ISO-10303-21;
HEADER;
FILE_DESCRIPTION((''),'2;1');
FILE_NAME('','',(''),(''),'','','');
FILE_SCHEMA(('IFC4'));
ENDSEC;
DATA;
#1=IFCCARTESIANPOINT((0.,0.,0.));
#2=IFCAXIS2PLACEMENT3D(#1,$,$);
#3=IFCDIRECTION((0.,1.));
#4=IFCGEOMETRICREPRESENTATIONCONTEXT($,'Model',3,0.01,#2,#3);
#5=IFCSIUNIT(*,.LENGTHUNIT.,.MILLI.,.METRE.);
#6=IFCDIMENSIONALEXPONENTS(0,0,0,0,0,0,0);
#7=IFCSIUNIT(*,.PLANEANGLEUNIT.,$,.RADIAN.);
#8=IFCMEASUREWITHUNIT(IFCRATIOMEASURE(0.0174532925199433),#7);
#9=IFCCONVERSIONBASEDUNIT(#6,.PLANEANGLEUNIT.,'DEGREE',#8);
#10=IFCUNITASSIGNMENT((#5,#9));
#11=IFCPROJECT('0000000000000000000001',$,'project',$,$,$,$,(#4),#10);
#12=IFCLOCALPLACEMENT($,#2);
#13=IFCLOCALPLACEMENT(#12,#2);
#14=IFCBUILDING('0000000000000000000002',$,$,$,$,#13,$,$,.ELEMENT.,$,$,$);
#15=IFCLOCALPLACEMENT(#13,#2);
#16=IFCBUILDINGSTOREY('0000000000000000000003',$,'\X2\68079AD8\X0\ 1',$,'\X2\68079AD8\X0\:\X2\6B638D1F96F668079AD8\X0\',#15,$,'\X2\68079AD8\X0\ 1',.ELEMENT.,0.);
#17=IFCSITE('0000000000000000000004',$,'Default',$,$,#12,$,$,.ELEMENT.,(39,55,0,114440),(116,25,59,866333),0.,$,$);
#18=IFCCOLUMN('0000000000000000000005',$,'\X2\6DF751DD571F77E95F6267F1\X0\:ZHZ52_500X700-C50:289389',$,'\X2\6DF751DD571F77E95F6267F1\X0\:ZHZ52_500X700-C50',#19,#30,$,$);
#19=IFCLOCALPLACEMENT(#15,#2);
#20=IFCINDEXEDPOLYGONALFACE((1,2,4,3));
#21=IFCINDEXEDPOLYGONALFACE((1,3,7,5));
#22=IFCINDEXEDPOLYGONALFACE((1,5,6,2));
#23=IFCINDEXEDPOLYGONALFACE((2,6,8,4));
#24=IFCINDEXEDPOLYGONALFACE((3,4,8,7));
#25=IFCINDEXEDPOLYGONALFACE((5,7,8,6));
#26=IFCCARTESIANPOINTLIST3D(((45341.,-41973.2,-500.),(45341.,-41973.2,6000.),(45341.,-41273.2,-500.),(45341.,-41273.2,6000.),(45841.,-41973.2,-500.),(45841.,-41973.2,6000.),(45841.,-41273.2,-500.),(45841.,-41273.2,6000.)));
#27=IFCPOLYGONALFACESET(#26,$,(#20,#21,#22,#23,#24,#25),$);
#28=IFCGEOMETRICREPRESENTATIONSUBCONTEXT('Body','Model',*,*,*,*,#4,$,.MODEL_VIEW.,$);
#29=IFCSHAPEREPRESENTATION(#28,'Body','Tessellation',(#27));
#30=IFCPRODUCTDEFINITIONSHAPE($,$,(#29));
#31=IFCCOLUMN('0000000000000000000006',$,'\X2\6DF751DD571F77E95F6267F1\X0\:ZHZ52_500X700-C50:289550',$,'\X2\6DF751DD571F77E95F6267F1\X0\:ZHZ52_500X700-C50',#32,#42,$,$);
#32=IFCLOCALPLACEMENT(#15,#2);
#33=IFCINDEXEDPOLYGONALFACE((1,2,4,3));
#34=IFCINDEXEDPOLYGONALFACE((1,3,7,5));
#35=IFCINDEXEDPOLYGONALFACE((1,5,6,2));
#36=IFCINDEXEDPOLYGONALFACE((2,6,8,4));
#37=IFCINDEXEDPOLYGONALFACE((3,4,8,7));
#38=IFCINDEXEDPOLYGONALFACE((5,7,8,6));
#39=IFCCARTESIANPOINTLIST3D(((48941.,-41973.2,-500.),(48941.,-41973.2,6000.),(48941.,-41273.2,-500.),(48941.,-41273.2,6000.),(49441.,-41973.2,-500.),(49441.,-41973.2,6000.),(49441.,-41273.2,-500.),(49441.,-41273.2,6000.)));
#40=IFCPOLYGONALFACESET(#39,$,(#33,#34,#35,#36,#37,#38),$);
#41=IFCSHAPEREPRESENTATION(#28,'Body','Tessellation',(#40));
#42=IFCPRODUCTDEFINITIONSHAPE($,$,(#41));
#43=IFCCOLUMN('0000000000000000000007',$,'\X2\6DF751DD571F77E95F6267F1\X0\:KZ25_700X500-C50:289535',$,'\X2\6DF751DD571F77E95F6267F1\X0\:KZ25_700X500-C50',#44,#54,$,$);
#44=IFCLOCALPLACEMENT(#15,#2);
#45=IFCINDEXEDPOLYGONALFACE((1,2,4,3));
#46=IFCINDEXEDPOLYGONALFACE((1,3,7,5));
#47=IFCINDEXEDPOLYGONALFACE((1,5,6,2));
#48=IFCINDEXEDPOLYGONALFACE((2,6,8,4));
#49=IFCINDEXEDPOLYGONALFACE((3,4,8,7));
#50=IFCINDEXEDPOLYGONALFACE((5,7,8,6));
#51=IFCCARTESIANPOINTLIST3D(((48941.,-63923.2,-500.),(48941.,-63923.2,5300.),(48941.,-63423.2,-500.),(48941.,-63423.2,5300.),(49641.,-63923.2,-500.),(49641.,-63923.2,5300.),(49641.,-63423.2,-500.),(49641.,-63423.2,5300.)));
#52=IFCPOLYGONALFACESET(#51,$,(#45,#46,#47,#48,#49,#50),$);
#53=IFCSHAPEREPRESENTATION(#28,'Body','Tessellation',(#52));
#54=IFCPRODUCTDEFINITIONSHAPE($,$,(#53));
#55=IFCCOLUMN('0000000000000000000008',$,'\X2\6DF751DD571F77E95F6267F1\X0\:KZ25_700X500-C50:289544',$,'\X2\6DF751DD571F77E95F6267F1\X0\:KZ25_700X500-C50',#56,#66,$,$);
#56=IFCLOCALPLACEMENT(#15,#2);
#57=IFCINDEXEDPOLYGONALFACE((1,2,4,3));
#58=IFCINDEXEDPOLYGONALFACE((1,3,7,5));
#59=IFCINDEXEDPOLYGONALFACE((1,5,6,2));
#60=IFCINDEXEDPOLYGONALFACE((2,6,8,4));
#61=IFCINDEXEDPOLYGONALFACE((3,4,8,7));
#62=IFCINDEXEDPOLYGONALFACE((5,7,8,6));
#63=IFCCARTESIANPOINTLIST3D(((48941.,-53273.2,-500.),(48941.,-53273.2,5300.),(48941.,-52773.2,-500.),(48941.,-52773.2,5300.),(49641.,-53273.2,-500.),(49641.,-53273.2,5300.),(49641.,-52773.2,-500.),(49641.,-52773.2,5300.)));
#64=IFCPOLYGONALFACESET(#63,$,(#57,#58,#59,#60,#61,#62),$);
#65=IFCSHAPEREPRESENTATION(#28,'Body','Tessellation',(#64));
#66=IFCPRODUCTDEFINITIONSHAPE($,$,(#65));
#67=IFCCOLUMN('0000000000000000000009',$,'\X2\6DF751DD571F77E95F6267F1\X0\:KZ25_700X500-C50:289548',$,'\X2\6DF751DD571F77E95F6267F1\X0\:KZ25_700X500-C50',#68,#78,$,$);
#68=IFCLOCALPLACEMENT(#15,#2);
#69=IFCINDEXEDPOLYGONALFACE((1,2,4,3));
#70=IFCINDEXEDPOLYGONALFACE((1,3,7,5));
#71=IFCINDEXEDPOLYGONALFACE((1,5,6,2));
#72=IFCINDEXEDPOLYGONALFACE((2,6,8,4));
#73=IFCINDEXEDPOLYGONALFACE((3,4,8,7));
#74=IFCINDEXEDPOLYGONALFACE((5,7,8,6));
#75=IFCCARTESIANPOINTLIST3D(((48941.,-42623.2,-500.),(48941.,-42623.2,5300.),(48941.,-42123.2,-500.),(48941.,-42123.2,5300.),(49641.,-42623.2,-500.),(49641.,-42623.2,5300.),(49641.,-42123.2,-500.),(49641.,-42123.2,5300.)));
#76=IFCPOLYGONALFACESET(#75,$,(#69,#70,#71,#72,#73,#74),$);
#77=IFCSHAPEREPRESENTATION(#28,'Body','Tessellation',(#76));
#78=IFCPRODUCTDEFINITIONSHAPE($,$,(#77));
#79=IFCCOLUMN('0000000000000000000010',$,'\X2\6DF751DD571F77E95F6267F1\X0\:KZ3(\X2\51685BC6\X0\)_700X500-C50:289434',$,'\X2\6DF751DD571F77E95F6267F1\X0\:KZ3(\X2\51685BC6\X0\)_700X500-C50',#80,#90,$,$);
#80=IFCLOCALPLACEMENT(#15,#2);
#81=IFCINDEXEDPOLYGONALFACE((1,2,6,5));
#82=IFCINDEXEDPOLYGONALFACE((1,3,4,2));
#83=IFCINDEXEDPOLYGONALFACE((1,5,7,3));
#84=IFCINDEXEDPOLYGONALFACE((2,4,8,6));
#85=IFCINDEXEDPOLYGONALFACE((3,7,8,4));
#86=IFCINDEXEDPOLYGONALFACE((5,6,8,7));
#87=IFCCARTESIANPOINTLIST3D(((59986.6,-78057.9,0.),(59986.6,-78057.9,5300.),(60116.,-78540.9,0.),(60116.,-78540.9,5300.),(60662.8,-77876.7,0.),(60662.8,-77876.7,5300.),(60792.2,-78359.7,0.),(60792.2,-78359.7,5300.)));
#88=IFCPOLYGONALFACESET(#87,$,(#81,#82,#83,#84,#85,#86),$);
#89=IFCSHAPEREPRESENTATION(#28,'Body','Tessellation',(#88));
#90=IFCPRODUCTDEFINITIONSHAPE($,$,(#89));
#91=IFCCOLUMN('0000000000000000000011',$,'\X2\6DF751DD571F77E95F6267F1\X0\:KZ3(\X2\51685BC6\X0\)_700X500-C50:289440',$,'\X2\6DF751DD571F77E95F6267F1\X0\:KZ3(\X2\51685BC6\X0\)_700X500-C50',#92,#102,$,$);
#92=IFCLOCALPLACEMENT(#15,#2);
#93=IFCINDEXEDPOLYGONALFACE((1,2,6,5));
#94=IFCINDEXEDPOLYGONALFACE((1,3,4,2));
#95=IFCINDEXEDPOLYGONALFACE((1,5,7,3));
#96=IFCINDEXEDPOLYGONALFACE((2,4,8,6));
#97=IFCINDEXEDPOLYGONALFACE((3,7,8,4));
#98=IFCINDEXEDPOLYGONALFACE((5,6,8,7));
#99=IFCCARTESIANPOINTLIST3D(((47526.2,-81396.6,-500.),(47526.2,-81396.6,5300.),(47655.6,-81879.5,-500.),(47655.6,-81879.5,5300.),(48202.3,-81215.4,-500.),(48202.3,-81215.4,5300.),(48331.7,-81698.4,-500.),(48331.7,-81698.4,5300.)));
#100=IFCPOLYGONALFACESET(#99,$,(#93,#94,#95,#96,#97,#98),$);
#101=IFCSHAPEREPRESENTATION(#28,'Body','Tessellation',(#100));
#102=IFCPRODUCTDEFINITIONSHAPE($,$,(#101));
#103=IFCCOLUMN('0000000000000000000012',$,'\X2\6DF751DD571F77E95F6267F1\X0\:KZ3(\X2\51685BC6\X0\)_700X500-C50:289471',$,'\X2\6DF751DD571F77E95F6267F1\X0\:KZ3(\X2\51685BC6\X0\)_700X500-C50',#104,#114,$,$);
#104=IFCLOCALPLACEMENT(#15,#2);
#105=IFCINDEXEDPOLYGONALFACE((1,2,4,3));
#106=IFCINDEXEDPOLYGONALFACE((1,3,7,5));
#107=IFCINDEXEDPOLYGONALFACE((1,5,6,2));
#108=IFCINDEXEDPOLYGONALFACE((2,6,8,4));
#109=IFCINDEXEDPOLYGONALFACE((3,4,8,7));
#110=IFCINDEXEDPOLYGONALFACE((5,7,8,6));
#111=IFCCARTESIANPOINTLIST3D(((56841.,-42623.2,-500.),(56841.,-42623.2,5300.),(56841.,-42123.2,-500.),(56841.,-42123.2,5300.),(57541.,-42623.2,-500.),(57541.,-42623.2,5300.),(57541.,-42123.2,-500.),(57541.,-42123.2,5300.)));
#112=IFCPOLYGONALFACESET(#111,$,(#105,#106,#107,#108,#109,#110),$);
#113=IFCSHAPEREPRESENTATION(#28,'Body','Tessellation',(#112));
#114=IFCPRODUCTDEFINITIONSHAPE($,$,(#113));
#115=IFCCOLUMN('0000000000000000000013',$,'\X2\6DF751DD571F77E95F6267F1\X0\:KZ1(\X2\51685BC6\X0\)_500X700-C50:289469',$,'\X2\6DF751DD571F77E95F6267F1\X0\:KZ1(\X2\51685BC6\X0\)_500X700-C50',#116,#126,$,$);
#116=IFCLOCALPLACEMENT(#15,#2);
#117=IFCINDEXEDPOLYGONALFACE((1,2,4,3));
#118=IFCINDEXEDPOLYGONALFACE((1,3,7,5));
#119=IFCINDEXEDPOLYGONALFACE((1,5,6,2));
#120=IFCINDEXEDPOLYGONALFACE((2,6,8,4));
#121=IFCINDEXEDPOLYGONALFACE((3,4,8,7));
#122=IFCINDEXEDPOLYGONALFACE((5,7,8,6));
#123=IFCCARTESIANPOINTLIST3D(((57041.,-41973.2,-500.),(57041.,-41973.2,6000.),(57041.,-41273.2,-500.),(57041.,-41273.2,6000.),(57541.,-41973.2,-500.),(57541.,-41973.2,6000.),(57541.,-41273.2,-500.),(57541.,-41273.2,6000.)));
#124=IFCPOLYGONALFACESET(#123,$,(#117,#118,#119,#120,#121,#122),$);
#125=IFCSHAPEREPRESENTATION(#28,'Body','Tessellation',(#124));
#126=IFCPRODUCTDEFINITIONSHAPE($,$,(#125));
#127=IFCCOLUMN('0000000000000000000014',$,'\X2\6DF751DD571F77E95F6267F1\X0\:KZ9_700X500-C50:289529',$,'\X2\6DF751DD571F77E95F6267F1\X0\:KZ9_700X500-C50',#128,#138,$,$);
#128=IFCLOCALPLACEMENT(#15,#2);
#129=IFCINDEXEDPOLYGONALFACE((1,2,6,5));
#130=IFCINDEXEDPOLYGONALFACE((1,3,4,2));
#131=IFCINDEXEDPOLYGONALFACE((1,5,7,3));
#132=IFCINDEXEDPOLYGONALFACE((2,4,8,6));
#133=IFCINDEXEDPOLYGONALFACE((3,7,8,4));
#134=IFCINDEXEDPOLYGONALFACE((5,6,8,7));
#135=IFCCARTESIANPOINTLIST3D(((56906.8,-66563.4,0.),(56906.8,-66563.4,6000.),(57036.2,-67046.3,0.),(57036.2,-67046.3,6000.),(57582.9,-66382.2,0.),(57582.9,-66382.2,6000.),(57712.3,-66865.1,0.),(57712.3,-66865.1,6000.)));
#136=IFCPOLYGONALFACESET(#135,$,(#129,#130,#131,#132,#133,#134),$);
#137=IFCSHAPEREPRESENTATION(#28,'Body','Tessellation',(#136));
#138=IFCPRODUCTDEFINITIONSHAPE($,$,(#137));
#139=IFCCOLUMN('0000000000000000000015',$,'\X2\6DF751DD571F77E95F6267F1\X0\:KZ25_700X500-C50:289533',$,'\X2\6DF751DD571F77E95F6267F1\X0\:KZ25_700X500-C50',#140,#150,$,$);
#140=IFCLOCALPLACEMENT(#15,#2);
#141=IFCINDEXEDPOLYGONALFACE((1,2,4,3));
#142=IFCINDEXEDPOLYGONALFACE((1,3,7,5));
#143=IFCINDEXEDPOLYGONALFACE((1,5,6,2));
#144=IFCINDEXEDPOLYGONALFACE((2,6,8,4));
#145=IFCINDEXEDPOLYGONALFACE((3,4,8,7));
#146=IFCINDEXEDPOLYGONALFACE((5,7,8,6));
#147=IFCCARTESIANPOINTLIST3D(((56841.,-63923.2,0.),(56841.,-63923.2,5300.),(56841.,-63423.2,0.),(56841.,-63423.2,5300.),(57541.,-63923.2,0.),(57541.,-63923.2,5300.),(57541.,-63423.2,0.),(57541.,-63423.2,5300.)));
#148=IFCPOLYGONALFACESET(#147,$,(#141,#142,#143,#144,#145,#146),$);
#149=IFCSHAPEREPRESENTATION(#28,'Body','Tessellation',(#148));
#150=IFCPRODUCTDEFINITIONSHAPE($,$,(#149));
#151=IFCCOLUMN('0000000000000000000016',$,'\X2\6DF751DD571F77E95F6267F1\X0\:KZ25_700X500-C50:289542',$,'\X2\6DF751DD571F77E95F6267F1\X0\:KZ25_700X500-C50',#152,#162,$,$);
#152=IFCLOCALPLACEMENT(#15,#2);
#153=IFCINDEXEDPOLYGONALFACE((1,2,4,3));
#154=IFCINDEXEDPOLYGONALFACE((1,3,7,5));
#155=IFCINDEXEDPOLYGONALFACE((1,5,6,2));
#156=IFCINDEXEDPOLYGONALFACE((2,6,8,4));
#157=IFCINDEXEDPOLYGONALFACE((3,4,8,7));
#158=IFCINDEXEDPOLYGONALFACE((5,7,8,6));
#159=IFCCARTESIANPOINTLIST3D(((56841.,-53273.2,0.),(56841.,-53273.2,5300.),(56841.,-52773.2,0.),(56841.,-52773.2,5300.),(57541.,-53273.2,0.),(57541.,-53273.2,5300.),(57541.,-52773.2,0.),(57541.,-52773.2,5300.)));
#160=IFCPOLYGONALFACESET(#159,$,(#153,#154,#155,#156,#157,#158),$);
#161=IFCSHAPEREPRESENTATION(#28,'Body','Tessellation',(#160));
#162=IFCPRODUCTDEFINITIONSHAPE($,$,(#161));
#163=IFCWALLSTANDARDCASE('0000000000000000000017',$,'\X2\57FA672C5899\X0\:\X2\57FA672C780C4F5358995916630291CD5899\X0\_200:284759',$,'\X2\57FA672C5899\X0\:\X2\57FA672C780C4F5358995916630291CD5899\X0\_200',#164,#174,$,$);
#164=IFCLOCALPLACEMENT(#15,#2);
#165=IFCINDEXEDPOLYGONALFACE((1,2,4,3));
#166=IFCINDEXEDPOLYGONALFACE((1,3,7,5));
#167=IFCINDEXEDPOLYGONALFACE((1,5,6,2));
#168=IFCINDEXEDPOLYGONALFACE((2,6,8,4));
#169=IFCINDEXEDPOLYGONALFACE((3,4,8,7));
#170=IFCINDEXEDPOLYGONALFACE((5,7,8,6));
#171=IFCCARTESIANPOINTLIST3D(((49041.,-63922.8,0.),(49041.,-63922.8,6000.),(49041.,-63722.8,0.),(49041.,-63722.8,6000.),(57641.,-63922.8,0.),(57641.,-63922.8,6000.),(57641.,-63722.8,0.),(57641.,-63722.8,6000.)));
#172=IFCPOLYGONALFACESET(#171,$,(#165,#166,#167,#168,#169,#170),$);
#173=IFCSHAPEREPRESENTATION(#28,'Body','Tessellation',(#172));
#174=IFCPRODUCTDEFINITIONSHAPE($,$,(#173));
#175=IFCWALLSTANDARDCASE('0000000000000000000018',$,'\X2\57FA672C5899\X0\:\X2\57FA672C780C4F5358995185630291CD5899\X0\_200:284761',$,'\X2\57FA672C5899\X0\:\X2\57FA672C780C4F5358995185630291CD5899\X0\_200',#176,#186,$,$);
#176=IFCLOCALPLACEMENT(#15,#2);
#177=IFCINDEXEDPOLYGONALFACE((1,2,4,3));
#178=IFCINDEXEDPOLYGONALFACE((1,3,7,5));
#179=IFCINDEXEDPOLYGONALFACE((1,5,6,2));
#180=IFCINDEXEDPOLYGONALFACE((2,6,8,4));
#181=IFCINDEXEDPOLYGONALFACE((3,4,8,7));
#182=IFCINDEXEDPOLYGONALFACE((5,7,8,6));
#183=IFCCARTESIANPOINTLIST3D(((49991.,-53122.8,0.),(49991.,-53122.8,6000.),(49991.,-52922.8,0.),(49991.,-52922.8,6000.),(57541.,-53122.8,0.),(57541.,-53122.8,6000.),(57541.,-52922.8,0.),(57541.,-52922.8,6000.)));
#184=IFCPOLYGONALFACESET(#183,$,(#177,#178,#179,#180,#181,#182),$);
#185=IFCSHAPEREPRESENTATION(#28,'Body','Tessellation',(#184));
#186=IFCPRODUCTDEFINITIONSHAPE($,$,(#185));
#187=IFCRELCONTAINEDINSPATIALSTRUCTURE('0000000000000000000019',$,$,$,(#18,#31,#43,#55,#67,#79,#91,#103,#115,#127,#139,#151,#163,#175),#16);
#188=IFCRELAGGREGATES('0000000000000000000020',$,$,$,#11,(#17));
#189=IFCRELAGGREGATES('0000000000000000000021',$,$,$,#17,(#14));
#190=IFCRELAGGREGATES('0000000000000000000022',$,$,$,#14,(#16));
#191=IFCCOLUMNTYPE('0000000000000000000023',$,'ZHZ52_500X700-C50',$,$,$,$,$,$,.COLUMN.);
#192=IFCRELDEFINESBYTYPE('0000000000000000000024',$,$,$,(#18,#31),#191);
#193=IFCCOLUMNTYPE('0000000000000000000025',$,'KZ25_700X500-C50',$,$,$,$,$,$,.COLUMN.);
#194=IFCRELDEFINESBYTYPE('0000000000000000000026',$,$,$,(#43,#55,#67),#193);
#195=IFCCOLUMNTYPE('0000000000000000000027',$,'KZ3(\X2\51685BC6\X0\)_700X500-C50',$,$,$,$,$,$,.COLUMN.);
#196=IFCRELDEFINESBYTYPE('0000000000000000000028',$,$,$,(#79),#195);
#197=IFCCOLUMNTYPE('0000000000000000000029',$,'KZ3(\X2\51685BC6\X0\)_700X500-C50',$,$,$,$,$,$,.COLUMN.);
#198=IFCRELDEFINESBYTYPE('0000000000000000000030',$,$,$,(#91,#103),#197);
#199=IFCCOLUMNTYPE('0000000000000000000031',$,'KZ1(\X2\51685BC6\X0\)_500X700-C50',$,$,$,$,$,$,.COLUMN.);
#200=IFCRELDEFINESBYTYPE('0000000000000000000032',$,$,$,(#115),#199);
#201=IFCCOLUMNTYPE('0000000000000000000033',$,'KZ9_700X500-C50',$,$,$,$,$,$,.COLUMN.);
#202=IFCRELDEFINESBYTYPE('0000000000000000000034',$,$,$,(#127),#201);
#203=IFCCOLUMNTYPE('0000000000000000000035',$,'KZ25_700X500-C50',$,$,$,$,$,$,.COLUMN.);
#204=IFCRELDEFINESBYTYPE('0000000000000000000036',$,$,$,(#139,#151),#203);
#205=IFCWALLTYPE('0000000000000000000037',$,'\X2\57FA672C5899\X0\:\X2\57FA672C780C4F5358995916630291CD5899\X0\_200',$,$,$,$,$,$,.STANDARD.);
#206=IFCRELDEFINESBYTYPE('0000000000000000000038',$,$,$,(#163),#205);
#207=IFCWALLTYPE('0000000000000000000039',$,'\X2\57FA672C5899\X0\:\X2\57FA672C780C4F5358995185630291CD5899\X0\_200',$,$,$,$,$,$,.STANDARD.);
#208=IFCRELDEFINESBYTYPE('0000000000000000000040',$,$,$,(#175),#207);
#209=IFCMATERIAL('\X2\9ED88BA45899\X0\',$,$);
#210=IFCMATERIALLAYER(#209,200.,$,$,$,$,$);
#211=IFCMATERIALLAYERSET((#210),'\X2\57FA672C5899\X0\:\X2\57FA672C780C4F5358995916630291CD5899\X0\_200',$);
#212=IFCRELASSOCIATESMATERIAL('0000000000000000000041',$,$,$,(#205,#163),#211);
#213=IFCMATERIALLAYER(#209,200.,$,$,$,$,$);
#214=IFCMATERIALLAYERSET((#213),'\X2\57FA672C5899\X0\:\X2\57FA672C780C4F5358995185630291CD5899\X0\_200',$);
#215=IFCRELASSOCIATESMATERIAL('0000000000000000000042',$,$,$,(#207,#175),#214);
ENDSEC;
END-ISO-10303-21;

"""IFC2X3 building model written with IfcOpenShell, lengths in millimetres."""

from ifc_helpers import new_model, entity, si_unit, converted_unit, direction, frame, frame_2d, origin, origin_2d_with_axis, place, context, subcontext, project, spatial, rectangle, extrude, source, transform, mapped, material, layer, layer_set, layer_usage, type_object, type_shapes, element, save


model = new_model("IFC2X3")

# Units and contexts
model_context = context("Model", 3, precision=0.01, world=origin(), true_north=direction((0.0, 1.0)))
body_context = subcontext(model_context, "Body", "Model", "MODEL_VIEW")
ifc_project = project(units=[si_unit("LENGTHUNIT", "METRE", prefix="MILLI"), converted_unit("PLANEANGLEUNIT", "DEGREE", entity("IfcRatioMeasure", 0.0174532925199433), si_unit("PLANEANGLEUNIT", "RADIAN"), dimensions=[0, 0, 0, 0, 0, 0, 0])], contexts=[model_context])

# Site, building, storey
site_placement = place(None, origin())
site = spatial("IfcSite", under=ifc_project, at=site_placement, Name="Default", CompositionType="ELEMENT", RefLatitude=(39, 55, 0, 114440), RefLongitude=(116, 25, 59, 866333), RefElevation=0.0)
building_placement = place(site_placement, origin())
building = spatial("IfcBuilding", under=site, at=building_placement, CompositionType="ELEMENT")
storey_placement = place(building_placement, origin())
storey = spatial("IfcBuildingStorey", under=building, at=storey_placement, Name="标高 1", ObjectType="标高:正负零标高", LongName="标高 1", CompositionType="ELEMENT", Elevation=0.0)

# Columns
column_type_1 = type_object("IfcColumnType", Name="ZHZ52_500X700-C50", PredefinedType="COLUMN")
shared_shape_1 = source(origin(), body_context, "Body", "SweptSolid", [
    extrude(rectangle(XDim=700.0, YDim=500.0, at=origin_2d_with_axis()), frame((0.0, 0.0, -500.0), z_axis=(0.0, 0.0, 1.0), x_axis=(0.0, -1.0, 0.0)), (0.0, 0.0, 1.0), 6500.0),
])
type_shapes(column_type_1, [shared_shape_1])
for number, where, name in (
    (1, (45591.0, -41623.2, 0.0), "混凝土矩形柱:ZHZ52_500X700-C50:289389"),
    (2, (49191.0, -41623.2, 0.0), "混凝土矩形柱:ZHZ52_500X700-C50:289550"),
):
    element("IfcColumn", number, at=place(building_placement, frame(where)), inside=storey, type_object=column_type_1, Name=name, ObjectType="混凝土矩形柱:ZHZ52_500X700-C50", context=body_context, shape_type="MappedRepresentation", body=[
        mapped(shared_shape_1, transform((0.0, 0.0, 0.0), scale=1.0)),
    ])
column_type_2 = type_object("IfcColumnType", Name="KZ25_700X500-C50", PredefinedType="COLUMN")
shared_shape_2 = source(origin(), body_context, "Body", "SweptSolid", [
    extrude(rectangle(XDim=500.0, YDim=700.0, at=origin_2d_with_axis()), frame((0.0, 0.0, -500.0), z_axis=(0.0, 0.0, 1.0), x_axis=(0.0, -1.0, 0.0)), (0.0, 0.0, 1.0), 5800.0),
])
type_shapes(column_type_2, [shared_shape_2])
for number, where, name in (
    (3, (49291.0, -63673.2, 0.0), "混凝土矩形柱:KZ25_700X500-C50:289535"),
    (4, (49291.0, -53023.2, 0.0), "混凝土矩形柱:KZ25_700X500-C50:289544"),
    (5, (49291.0, -42373.2, 0.0), "混凝土矩形柱:KZ25_700X500-C50:289548"),
):
    element("IfcColumn", number, at=place(building_placement, frame(where)), inside=storey, type_object=column_type_2, Name=name, ObjectType="混凝土矩形柱:KZ25_700X500-C50", context=body_context, shape_type="MappedRepresentation", body=[
        mapped(shared_shape_2, transform((0.0, 0.0, 0.0), scale=1.0)),
    ])
column_type_3 = type_object("IfcColumnType", Name="KZ3(全密)_700X500-C50", PredefinedType="COLUMN")
shared_shape_3 = source(origin(), body_context, "Body", "SweptSolid", [
    extrude(rectangle(XDim=500.0, YDim=700.0, at=origin_2d_with_axis()), frame((0.0, 0.0, 0.0), z_axis=(0.0, 0.0, 1.0), x_axis=(0.0, -1.0, 0.0)), (0.0, 0.0, 1.0), 5300.0),
])
type_shapes(column_type_3, [shared_shape_3])
column_1_placement = place(building_placement, frame((60389.4, -78208.8, 0.0), z_axis=(0.0, 0.0, 1.0), x_axis=(0.965926, 0.258819, 0.0)))
element("IfcColumn", 6, at=column_1_placement, inside=storey, type_object=column_type_3, Name="混凝土矩形柱:KZ3(全密)_700X500-C50:289434", ObjectType="混凝土矩形柱:KZ3(全密)_700X500-C50", context=body_context, shape_type="MappedRepresentation", body=[
    mapped(shared_shape_3, transform((0.0, 0.0, 0.0), scale=1.0)),
])
column_type_4 = type_object("IfcColumnType", Name="KZ3(全密)_700X500-C50", PredefinedType="COLUMN")
shared_shape_4 = source(origin(), body_context, "Body", "SweptSolid", [
    extrude(rectangle(XDim=500.0, YDim=700.0, at=origin_2d_with_axis()), frame((0.0, 0.0, -500.0), z_axis=(0.0, 0.0, 1.0), x_axis=(0.0, -1.0, 0.0)), (0.0, 0.0, 1.0), 5800.0),
])
type_shapes(column_type_4, [shared_shape_4])
column_2_placement = place(building_placement, frame((47928.9, -81547.5, 0.0), z_axis=(0.0, 0.0, 1.0), x_axis=(0.965926, 0.258819, 0.0)))
element("IfcColumn", 7, at=column_2_placement, inside=storey, type_object=column_type_4, Name="混凝土矩形柱:KZ3(全密)_700X500-C50:289440", ObjectType="混凝土矩形柱:KZ3(全密)_700X500-C50", context=body_context, shape_type="MappedRepresentation", body=[
    mapped(shared_shape_4, transform((0.0, 0.0, 0.0), scale=1.0)),
])
column_3_placement = place(building_placement, frame((57191.0, -42373.2, 0.0)))
element("IfcColumn", 8, at=column_3_placement, inside=storey, type_object=column_type_4, Name="混凝土矩形柱:KZ3(全密)_700X500-C50:289471", ObjectType="混凝土矩形柱:KZ3(全密)_700X500-C50", context=body_context, shape_type="MappedRepresentation", body=[
    mapped(shared_shape_4, transform((0.0, 0.0, 0.0), scale=1.0)),
])
column_type_5 = type_object("IfcColumnType", Name="KZ1(全密)_500X700-C50", PredefinedType="COLUMN")
shared_shape_5 = source(origin(), body_context, "Body", "SweptSolid", [
    extrude(rectangle(XDim=700.0, YDim=500.0, at=origin_2d_with_axis()), frame((0.0, 0.0, -500.0), z_axis=(0.0, 0.0, 1.0), x_axis=(0.0, -1.0, 0.0)), (0.0, 0.0, 1.0), 6500.0),
])
type_shapes(column_type_5, [shared_shape_5])
column_4_placement = place(building_placement, frame((57291.0, -41623.2, 0.0)))
element("IfcColumn", 9, at=column_4_placement, inside=storey, type_object=column_type_5, Name="混凝土矩形柱:KZ1(全密)_500X700-C50:289469", ObjectType="混凝土矩形柱:KZ1(全密)_500X700-C50", context=body_context, shape_type="MappedRepresentation", body=[
    mapped(shared_shape_5, transform((0.0, 0.0, 0.0), scale=1.0)),
])
column_type_6 = type_object("IfcColumnType", Name="KZ9_700X500-C50", PredefinedType="COLUMN")
shared_shape_6 = source(origin(), body_context, "Body", "SweptSolid", [
    extrude(rectangle(XDim=500.0, YDim=700.0, at=origin_2d_with_axis()), frame((0.0, 0.0, 0.0), z_axis=(0.0, 0.0, 1.0), x_axis=(0.0, -1.0, 0.0)), (0.0, 0.0, 1.0), 6000.0),
])
type_shapes(column_type_6, [shared_shape_6])
column_5_placement = place(building_placement, frame((57309.5, -66714.2, 0.0), z_axis=(0.0, 0.0, 1.0), x_axis=(0.965926, 0.258819, 0.0)))
element("IfcColumn", 10, at=column_5_placement, inside=storey, type_object=column_type_6, Name="混凝土矩形柱:KZ9_700X500-C50:289529", ObjectType="混凝土矩形柱:KZ9_700X500-C50", context=body_context, shape_type="MappedRepresentation", body=[
    mapped(shared_shape_6, transform((0.0, 0.0, 0.0), scale=1.0)),
])
column_type_7 = type_object("IfcColumnType", Name="KZ25_700X500-C50", PredefinedType="COLUMN")
shared_shape_7 = source(origin(), body_context, "Body", "SweptSolid", [
    extrude(rectangle(XDim=500.0, YDim=700.0, at=origin_2d_with_axis()), frame((0.0, 0.0, 0.0), z_axis=(0.0, 0.0, 1.0), x_axis=(0.0, -1.0, 0.0)), (0.0, 0.0, 1.0), 5300.0),
])
type_shapes(column_type_7, [shared_shape_7])
for number, where, name in (
    (11, (57191.0, -63673.2, 0.0), "混凝土矩形柱:KZ25_700X500-C50:289533"),
    (12, (57191.0, -53023.2, 0.0), "混凝土矩形柱:KZ25_700X500-C50:289542"),
):
    element("IfcColumn", number, at=place(building_placement, frame(where)), inside=storey, type_object=column_type_7, Name=name, ObjectType="混凝土矩形柱:KZ25_700X500-C50", context=body_context, shape_type="MappedRepresentation", body=[
        mapped(shared_shape_7, transform((0.0, 0.0, 0.0), scale=1.0)),
    ])

# Walls
ifc_material = material(Name="默认墙")
ifc_layer_1 = layer(ifc_material, 200.0)
ifc_layer_set_1 = layer_set([ifc_layer_1], Name="基本墙:基本砌体墙外挂重墙_200")
ifc_layer_usage_1 = layer_usage(ifc_layer_set_1, "AXIS2", "NEGATIVE", 100.0)
wall_type_1 = type_object("IfcWallType", Name="基本墙:基本砌体墙外挂重墙_200", PredefinedType="STANDARD", material=ifc_layer_set_1)
wall_1_placement = place(building_placement, frame((49041.0, -63822.8, 0.0)))
element("IfcWallStandardCase", 13, at=wall_1_placement, inside=storey, type_object=wall_type_1, material=ifc_layer_usage_1, Name="基本墙:基本砌体墙外挂重墙_200:284759", ObjectType="基本墙:基本砌体墙外挂重墙_200", context=body_context, shape_type="SweptSolid", body=[
    extrude(rectangle(XDim=8600.0, YDim=200.0, at=frame_2d((4300.0, 0.0), x_axis=(-1.0, 0.0))), origin(), (0.0, 0.0, 1.0), 6000.0),
])
ifc_layer_2 = layer(ifc_material, 200.0)
ifc_layer_set_2 = layer_set([ifc_layer_2], Name="基本墙:基本砌体墙内挂重墙_200")
ifc_layer_usage_2 = layer_usage(ifc_layer_set_2, "AXIS2", "NEGATIVE", 100.0)
wall_type_2 = type_object("IfcWallType", Name="基本墙:基本砌体墙内挂重墙_200", PredefinedType="STANDARD", material=ifc_layer_set_2)
wall_2_placement = place(building_placement, frame((49991.0, -53022.8, 0.0)))
element("IfcWallStandardCase", 14, at=wall_2_placement, inside=storey, type_object=wall_type_2, material=ifc_layer_usage_2, Name="基本墙:基本砌体墙内挂重墙_200:284761", ObjectType="基本墙:基本砌体墙内挂重墙_200", context=body_context, shape_type="SweptSolid", body=[
    extrude(rectangle(XDim=7550.0, YDim=200.0, at=frame_2d((3775.0, 0.0), x_axis=(-1.0, 0.0))), origin(), (0.0, 0.0, 1.0), 6000.0),
])

save(model, "model.ifc")
